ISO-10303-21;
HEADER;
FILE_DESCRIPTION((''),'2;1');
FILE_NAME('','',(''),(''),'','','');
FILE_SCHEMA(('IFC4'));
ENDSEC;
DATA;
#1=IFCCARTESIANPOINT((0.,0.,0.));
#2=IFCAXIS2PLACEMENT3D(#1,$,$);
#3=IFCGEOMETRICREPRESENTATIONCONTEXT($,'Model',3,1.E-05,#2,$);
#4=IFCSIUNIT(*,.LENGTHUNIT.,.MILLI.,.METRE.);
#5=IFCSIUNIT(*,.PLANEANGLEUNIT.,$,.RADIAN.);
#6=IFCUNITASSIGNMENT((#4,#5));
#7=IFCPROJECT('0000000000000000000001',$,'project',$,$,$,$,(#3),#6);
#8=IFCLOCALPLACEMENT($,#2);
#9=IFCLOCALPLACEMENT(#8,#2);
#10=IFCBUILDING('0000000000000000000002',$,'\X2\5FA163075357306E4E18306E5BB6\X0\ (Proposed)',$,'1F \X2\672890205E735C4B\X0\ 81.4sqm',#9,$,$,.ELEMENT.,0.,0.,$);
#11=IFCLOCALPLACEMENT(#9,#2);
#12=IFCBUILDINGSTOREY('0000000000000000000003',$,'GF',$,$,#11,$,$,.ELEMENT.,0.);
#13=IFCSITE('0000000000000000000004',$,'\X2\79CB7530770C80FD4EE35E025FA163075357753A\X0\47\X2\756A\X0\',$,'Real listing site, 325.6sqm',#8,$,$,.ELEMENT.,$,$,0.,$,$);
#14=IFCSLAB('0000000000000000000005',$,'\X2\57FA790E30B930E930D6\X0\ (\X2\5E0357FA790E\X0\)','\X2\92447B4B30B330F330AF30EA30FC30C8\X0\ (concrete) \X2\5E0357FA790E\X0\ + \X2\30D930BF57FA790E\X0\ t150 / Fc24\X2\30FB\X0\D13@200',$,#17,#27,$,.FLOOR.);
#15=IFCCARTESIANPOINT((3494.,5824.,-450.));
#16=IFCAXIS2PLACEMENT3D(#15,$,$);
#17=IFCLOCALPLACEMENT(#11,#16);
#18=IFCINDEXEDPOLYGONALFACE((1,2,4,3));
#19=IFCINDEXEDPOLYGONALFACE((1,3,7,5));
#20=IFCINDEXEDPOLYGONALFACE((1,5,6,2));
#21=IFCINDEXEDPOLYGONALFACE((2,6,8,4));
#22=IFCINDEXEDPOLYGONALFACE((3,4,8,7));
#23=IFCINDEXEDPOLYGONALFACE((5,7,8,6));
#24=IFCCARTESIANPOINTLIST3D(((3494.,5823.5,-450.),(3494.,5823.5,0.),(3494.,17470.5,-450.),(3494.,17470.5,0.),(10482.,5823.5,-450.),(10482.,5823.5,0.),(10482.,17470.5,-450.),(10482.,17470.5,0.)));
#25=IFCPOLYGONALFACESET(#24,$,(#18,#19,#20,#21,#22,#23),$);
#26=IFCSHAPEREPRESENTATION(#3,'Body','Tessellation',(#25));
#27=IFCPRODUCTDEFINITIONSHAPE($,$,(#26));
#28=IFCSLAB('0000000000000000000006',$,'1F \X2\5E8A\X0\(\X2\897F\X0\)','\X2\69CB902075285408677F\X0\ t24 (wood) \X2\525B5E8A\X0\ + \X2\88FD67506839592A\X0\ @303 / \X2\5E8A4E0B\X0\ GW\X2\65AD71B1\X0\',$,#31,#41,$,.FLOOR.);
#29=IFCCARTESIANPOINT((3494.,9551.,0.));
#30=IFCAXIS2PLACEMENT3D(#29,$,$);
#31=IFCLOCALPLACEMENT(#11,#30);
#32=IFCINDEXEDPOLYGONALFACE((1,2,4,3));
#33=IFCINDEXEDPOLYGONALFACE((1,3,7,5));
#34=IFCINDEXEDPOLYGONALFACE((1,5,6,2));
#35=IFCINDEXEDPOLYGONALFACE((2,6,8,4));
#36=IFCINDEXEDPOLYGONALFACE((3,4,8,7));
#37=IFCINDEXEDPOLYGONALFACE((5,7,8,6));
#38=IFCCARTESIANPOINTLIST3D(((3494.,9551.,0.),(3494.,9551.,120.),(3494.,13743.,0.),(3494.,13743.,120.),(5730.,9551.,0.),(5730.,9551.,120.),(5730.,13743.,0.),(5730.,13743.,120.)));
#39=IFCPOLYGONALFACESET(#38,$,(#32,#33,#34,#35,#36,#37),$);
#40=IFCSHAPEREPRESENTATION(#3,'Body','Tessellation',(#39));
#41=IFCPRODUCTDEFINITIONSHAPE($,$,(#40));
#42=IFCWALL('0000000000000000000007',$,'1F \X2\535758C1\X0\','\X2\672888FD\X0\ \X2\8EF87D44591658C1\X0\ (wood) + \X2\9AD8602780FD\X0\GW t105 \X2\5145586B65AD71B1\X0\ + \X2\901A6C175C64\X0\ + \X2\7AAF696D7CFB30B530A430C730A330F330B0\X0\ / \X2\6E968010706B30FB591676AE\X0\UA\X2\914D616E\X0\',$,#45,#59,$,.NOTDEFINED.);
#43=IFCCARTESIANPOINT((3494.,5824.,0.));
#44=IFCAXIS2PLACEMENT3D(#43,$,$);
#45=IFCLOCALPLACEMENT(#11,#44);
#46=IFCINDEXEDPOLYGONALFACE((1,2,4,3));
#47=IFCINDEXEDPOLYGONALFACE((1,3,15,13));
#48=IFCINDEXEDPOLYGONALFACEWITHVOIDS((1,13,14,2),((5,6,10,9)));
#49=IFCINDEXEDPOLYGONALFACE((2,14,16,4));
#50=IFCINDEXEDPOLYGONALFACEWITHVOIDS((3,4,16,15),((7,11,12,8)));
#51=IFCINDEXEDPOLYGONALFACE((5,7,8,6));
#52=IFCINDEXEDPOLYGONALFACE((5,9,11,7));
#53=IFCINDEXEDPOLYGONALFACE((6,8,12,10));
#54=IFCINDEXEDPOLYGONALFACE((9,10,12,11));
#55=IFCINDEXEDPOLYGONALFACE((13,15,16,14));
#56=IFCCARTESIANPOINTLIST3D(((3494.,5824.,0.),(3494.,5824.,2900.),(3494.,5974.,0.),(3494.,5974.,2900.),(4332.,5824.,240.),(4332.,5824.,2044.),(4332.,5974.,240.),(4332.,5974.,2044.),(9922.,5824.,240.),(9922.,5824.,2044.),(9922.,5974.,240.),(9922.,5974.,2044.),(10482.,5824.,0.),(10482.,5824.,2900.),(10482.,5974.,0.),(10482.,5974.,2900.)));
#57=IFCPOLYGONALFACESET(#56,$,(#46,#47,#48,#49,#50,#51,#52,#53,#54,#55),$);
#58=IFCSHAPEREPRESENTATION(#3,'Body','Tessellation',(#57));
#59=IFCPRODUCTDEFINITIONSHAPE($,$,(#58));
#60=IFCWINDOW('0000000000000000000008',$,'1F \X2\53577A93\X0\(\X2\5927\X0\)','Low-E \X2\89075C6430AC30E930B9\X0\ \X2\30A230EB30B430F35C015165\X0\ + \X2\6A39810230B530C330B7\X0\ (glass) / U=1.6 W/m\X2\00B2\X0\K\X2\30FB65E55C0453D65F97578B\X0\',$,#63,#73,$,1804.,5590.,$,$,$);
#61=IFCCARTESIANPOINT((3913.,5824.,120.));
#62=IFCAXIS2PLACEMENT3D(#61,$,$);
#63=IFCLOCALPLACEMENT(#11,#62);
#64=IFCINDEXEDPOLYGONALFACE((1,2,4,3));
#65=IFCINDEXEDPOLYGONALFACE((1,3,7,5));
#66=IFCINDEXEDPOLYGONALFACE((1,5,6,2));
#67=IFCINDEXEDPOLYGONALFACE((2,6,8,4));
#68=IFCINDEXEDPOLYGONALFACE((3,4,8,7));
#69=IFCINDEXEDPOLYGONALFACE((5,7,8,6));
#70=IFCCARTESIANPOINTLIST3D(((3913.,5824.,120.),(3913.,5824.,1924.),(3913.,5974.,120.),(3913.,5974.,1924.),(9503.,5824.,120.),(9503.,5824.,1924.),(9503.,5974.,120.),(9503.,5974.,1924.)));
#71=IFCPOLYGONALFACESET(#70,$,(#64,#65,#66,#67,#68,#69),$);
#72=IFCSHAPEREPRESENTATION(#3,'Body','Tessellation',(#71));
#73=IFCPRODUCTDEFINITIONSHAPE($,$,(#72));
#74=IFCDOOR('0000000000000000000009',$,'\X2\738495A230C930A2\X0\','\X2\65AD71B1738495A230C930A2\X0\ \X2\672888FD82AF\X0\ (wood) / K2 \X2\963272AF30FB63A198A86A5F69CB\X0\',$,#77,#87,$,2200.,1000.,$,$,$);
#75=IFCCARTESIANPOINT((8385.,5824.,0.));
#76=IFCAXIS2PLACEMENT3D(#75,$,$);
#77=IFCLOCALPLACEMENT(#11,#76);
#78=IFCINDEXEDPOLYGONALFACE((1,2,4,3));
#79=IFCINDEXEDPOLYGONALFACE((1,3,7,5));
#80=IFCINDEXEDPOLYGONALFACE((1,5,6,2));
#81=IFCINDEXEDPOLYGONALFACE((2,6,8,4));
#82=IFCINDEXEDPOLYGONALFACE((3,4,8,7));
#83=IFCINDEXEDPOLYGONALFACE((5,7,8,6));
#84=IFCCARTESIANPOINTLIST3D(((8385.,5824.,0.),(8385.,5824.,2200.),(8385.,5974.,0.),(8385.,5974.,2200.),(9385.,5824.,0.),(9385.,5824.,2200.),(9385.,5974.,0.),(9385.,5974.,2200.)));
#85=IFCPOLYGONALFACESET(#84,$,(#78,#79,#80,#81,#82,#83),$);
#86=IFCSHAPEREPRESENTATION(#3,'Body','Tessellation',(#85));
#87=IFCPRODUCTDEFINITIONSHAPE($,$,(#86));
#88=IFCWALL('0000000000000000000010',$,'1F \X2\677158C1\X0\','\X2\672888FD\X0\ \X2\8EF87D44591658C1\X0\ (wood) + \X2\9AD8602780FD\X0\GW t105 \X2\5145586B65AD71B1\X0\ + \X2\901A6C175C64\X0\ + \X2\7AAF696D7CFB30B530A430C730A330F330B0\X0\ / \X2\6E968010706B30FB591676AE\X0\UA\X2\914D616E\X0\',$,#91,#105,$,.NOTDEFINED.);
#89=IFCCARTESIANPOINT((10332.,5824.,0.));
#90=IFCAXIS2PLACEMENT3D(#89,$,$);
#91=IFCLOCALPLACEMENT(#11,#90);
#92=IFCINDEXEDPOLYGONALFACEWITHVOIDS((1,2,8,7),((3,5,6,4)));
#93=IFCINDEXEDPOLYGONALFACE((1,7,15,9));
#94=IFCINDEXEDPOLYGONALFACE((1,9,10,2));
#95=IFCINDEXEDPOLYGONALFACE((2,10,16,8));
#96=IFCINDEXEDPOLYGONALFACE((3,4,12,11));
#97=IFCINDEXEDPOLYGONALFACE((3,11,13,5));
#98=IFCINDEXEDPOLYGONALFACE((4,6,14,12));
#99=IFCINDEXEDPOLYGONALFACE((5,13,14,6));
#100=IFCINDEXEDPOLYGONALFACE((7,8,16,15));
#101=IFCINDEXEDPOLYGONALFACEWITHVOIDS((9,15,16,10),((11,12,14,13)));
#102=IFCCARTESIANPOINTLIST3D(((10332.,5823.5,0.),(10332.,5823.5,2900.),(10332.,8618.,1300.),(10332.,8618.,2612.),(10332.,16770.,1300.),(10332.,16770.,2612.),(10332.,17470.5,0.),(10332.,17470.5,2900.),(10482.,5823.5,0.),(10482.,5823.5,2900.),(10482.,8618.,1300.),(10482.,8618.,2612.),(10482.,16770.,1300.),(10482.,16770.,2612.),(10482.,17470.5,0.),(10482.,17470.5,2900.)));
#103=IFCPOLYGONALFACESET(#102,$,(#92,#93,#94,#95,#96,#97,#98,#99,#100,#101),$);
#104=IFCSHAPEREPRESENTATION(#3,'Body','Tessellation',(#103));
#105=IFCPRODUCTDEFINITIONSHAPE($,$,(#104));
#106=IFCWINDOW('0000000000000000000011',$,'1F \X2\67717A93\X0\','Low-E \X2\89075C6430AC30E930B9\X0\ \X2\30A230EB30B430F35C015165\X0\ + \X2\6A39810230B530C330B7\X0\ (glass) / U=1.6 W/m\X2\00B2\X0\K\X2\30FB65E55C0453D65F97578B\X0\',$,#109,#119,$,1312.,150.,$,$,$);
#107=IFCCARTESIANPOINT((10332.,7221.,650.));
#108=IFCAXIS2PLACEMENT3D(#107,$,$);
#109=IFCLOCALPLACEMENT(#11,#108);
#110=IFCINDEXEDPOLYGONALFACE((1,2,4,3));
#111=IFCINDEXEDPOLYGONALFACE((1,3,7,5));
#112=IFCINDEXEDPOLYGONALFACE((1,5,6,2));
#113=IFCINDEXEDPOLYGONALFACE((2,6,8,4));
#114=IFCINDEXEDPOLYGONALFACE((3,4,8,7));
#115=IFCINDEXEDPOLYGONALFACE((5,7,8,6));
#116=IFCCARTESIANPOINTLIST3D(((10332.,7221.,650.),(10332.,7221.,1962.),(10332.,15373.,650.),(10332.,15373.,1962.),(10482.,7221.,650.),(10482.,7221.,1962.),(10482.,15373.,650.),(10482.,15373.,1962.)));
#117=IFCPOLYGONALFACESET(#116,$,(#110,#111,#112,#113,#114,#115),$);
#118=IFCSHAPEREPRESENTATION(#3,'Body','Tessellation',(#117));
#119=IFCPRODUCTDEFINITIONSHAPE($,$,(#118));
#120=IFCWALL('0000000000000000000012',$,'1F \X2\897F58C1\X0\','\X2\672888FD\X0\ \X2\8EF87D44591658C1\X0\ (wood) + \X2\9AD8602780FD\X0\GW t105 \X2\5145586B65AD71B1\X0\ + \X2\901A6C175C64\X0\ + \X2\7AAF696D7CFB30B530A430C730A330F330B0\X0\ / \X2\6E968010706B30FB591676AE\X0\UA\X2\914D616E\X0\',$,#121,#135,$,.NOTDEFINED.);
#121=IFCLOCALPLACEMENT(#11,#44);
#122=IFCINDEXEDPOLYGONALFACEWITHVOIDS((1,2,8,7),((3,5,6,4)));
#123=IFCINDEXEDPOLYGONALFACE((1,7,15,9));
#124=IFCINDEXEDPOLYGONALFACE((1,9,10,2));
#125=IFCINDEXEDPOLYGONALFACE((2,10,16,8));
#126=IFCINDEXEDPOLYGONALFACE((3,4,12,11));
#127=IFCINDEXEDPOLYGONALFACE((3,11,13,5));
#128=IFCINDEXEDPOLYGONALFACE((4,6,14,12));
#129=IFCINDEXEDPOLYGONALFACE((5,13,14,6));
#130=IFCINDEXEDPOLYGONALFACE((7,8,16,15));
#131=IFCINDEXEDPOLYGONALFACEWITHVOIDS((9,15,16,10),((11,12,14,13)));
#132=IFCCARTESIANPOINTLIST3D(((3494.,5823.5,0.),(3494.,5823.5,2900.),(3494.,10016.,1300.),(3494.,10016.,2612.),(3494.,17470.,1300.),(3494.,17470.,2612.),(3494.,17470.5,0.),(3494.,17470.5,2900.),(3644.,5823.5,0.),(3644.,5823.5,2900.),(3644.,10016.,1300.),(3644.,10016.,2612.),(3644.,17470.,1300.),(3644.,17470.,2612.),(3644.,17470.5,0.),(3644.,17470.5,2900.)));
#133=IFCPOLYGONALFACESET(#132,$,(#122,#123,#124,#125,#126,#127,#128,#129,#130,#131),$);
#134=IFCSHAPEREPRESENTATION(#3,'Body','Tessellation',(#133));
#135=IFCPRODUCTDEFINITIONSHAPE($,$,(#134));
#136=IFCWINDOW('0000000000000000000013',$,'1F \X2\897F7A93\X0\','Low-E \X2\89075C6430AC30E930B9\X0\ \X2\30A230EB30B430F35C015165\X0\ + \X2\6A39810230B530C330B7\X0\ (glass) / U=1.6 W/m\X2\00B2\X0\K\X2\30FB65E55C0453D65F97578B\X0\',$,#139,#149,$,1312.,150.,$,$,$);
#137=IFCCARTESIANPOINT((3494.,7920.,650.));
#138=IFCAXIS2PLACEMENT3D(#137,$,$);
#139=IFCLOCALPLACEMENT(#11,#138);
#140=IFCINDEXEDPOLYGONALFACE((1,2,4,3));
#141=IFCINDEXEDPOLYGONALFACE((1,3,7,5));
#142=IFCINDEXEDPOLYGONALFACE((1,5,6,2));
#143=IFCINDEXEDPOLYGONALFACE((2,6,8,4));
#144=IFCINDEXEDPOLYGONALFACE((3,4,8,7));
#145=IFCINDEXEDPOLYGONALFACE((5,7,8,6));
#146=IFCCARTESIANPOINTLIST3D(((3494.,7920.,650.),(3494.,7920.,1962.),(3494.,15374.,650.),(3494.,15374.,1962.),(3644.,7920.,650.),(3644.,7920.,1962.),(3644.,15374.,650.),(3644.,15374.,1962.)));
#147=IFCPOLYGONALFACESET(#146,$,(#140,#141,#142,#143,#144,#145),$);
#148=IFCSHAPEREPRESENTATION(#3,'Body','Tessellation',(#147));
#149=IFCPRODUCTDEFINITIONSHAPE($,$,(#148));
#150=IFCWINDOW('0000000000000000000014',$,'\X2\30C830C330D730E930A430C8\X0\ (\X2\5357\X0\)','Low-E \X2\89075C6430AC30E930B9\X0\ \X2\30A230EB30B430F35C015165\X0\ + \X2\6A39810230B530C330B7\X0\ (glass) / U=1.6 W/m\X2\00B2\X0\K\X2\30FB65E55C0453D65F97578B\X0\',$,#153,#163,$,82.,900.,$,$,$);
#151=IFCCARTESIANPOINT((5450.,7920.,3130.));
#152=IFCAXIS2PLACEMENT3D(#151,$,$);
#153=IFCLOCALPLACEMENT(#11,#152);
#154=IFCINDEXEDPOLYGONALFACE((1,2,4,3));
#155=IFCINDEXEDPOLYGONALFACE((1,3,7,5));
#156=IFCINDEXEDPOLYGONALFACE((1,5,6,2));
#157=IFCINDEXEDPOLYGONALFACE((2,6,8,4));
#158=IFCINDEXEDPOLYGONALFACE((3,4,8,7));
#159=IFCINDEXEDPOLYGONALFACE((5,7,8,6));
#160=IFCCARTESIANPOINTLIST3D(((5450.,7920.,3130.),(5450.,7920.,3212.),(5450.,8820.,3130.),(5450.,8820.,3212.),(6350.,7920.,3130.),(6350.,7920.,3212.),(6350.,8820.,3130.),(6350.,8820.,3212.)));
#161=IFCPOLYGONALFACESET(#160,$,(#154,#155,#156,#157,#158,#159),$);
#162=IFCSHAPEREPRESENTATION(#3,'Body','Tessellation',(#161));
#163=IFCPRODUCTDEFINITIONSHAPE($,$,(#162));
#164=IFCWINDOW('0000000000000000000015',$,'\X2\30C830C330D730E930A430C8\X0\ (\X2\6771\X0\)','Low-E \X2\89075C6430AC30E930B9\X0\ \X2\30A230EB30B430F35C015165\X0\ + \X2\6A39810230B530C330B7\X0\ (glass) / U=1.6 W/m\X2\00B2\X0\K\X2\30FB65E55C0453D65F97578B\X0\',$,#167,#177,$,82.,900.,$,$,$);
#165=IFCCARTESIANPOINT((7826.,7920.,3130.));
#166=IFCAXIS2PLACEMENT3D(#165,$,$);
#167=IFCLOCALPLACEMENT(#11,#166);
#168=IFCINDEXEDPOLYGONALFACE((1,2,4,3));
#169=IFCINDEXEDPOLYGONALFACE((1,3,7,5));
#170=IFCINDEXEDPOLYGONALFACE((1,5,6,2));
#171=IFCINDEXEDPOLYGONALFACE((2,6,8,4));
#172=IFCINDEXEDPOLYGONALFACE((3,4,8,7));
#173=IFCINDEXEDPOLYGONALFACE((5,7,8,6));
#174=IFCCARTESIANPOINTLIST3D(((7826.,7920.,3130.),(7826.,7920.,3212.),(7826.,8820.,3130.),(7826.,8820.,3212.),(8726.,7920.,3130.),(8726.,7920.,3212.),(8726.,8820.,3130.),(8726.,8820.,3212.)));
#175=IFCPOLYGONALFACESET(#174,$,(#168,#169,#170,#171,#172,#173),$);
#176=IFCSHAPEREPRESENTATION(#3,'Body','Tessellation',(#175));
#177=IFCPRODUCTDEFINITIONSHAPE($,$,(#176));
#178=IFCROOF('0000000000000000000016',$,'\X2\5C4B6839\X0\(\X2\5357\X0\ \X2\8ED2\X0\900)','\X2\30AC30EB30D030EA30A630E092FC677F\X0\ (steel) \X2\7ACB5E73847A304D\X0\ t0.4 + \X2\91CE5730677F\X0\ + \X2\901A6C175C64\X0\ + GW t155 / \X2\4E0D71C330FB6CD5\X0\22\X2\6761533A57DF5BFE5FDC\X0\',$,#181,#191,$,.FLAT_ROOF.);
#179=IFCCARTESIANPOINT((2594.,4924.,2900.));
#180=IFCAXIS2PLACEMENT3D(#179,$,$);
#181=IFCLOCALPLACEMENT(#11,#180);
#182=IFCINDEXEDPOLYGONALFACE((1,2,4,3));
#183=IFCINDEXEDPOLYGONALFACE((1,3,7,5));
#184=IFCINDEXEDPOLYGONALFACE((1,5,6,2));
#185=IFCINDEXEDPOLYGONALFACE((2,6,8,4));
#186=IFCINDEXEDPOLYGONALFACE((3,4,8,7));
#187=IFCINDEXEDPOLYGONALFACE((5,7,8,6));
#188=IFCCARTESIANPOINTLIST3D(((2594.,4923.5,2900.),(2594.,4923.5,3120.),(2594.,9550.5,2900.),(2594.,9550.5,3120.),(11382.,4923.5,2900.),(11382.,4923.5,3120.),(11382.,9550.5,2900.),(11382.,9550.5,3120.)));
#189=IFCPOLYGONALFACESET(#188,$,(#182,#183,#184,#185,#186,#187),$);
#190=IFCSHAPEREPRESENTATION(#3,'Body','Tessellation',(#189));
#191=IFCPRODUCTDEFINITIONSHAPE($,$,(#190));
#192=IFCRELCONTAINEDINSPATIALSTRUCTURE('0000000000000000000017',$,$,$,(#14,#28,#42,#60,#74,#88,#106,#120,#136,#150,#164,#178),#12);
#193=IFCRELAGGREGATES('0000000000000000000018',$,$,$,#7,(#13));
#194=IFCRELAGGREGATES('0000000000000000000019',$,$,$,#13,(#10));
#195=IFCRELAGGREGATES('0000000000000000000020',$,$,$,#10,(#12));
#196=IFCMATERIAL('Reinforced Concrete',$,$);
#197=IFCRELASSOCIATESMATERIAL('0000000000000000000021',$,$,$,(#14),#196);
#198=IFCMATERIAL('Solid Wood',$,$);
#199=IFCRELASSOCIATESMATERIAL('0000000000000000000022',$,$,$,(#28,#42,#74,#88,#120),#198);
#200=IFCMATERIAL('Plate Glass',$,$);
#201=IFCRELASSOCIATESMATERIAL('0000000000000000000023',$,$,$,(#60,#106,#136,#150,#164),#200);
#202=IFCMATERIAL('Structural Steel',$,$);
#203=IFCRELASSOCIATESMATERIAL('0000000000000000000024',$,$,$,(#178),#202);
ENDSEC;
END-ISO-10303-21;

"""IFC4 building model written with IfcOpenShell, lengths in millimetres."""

from ifc_helpers import new_model, si_unit, frame, frame_2d, origin, place, context, project, spatial, rectangle, extrude, material, element, fill, save


model = new_model("IFC4")

# Units and contexts
model_context = context("Model", 3, precision=1e-05, world=origin())
ifc_project = project(units=[si_unit("LENGTHUNIT", "METRE", prefix="MILLI"), si_unit("PLANEANGLEUNIT", "RADIAN")], contexts=[model_context])

# Site, building, storey
site_placement = place(None, origin())
site = spatial("IfcSite", under=ifc_project, at=site_placement, Name="秋田県能代市御指南町47番", ObjectType="Real listing site, 325.6sqm", CompositionType="ELEMENT", RefElevation=0.0)
building_placement = place(site_placement, origin())
building = spatial("IfcBuilding", under=site, at=building_placement, Name="御指南の丘の家 (Proposed)", ObjectType="1F 木造平屋 81.4sqm", CompositionType="ELEMENT", ElevationOfRefHeight=0.0, ElevationOfTerrain=0.0)
storey_placement = place(building_placement, origin())
storey = spatial("IfcBuildingStorey", under=building, at=storey_placement, Name="GF", CompositionType="ELEMENT", Elevation=0.0)

# Slabs
ifc_material_1 = material(Name="Reinforced Concrete")
slab_1_placement = place(storey_placement, frame((3494.0, 5824.0, -450.0)))
element("IfcSlab", 1, at=slab_1_placement, inside=storey, material=ifc_material_1, Name="基礎スラブ (布基礎)", Description="鉄筋コンクリート (concrete) 布基礎 + ベタ基礎 t150 / Fc24・D13@200", PredefinedType="FLOOR", context=model_context, shape_type="SweptSolid", body=[
    extrude(rectangle(XDim=6988.0, YDim=11647.0, at=frame_2d((3494.0, 5823.0))), frame((3494.0, 5824.0, -450.0)), (0.0, 0.0, 1.0), 450.0),
])
ifc_material_2 = material(Name="Solid Wood")
slab_2_placement = place(storey_placement, frame((3494.0, 9551.0, 0.0)))
element("IfcSlab", 2, at=slab_2_placement, inside=storey, material=ifc_material_2, Name="1F 床(西)", Description="構造用合板 t24 (wood) 剛床 + 製材根太 @303 / 床下 GW断熱", PredefinedType="FLOOR", context=model_context, shape_type="SweptSolid", body=[
    extrude(rectangle(XDim=2236.0, YDim=4192.0, at=frame_2d((1118.0, 2096.0))), frame((3494.0, 9551.0, 0.0)), (0.0, 0.0, 1.0), 120.0),
])

# Wall, openings, window, door
wall_1_placement = place(storey_placement, frame((3494.0, 5824.0, 0.0)))
wall_1 = element("IfcWall", 3, at=wall_1_placement, inside=storey, material=ifc_material_2, Name="1F 南壁", Description="木製 軸組外壁 (wood) + 高性能GW t105 充填断熱 + 通気層 + 窯業系サイディング / 準耐火・外皮UA配慮", PredefinedType="NOTDEFINED", context=model_context, shape_type="SweptSolid", body=[
    extrude(rectangle(XDim=6988.0, YDim=150.0, at=frame_2d((3494.0, 75.0))), frame((3494.0, 5824.0, 0.0)), (0.0, 0.0, 1.0), 2900.0),
])
opening_1_placement = place(storey_placement, frame((3913.0, 5824.0, 120.0)))
opening_1 = element("IfcOpeningElement", 4, at=opening_1_placement, cuts=wall_1, PredefinedType="NOTDEFINED", context=model_context, shape_type="SweptSolid", body=[
    extrude(rectangle(XDim=5590.0, YDim=150.0, at=frame_2d((2795.0, 75.0))), frame((3913.0, 5824.0, 120.0)), (0.0, 0.0, 1.0), 1804.0),
])
opening_2_placement = place(storey_placement, frame((8385.0, 5824.0, 0.0)))
opening_2 = element("IfcOpeningElement", 5, at=opening_2_placement, cuts=wall_1, PredefinedType="NOTDEFINED", context=model_context, shape_type="SweptSolid", body=[
    extrude(rectangle(XDim=1000.0, YDim=150.0, at=frame_2d((500.0, 75.0))), frame((8385.0, 5824.0, 0.0)), (0.0, 0.0, 1.0), 2200.0),
])
ifc_material_3 = material(Name="Plate Glass")
window_1_placement = place(storey_placement, frame((3913.0, 5824.0, 120.0)))
window_1 = element("IfcWindow", 6, at=window_1_placement, inside=storey, material=ifc_material_3, Name="1F 南窓(大)", Description="Low-E 複層ガラス アルゴン封入 + 樹脂サッシ (glass) / U=1.6 W/m²K・日射取得型", OverallHeight=1804.0, OverallWidth=5590.0, context=model_context, shape_type="SweptSolid", body=[
    extrude(rectangle(XDim=5590.0, YDim=150.0, at=frame_2d((2795.0, 75.0))), frame((3913.0, 5824.0, 120.0)), (0.0, 0.0, 1.0), 1804.0),
])
fill(opening_1, window_1)
door_placement = place(storey_placement, frame((8385.0, 5824.0, 0.0)))
door = element("IfcDoor", 7, at=door_placement, inside=storey, material=ifc_material_2, Name="玄関ドア", Description="断熱玄関ドア 木製芯 (wood) / K2 防犯・採風機構", OverallHeight=2200.0, OverallWidth=1000.0, context=model_context, shape_type="SweptSolid", body=[
    extrude(rectangle(XDim=1000.0, YDim=150.0, at=frame_2d((500.0, 75.0))), frame((8385.0, 5824.0, 0.0)), (0.0, 0.0, 1.0), 2200.0),
])
fill(opening_2, door)

# Walls, openings, windows
wall_2_placement = place(storey_placement, frame((10332.0, 5824.0, 0.0)))
wall_2 = element("IfcWall", 8, at=wall_2_placement, inside=storey, material=ifc_material_2, Name="1F 東壁", Description="木製 軸組外壁 (wood) + 高性能GW t105 充填断熱 + 通気層 + 窯業系サイディング / 準耐火・外皮UA配慮", PredefinedType="NOTDEFINED", context=model_context, shape_type="SweptSolid", body=[
    extrude(rectangle(XDim=150.0, YDim=11647.0, at=frame_2d((75.0, 5823.0))), frame((10332.0, 5824.0, 0.0)), (0.0, 0.0, 1.0), 2900.0),
])
opening_3_placement = place(storey_placement, frame((10332.0, 7221.0, 650.0)))
opening_3 = element("IfcOpeningElement", 9, at=opening_3_placement, cuts=wall_2, PredefinedType="NOTDEFINED", context=model_context, shape_type="SweptSolid", body=[
    extrude(rectangle(XDim=150.0, YDim=8152.0, at=frame_2d((75.0, 4076.0))), frame((10332.0, 7221.0, 650.0)), (0.0, 0.0, 1.0), 1312.0),
])
window_2_placement = place(storey_placement, frame((10332.0, 7221.0, 650.0)))
window_2 = element("IfcWindow", 10, at=window_2_placement, inside=storey, material=ifc_material_3, Name="1F 東窓", Description="Low-E 複層ガラス アルゴン封入 + 樹脂サッシ (glass) / U=1.6 W/m²K・日射取得型", OverallHeight=1312.0, OverallWidth=150.0, context=model_context, shape_type="SweptSolid", body=[
    extrude(rectangle(XDim=150.0, YDim=8152.0, at=frame_2d((75.0, 4076.0))), frame((10332.0, 7221.0, 650.0)), (0.0, 0.0, 1.0), 1312.0),
])
fill(opening_3, window_2)
wall_3_placement = place(storey_placement, frame((3494.0, 5824.0, 0.0)))
wall_3 = element("IfcWall", 11, at=wall_3_placement, inside=storey, material=ifc_material_2, Name="1F 西壁", Description="木製 軸組外壁 (wood) + 高性能GW t105 充填断熱 + 通気層 + 窯業系サイディング / 準耐火・外皮UA配慮", PredefinedType="NOTDEFINED", context=model_context, shape_type="SweptSolid", body=[
    extrude(rectangle(XDim=150.0, YDim=11647.0, at=frame_2d((75.0, 5823.0))), frame((3494.0, 5824.0, 0.0)), (0.0, 0.0, 1.0), 2900.0),
])
opening_4_placement = place(storey_placement, frame((3494.0, 7920.0, 650.0)))
opening_4 = element("IfcOpeningElement", 12, at=opening_4_placement, cuts=wall_3, PredefinedType="NOTDEFINED", context=model_context, shape_type="SweptSolid", body=[
    extrude(rectangle(XDim=150.0, YDim=7454.0, at=frame_2d((75.0, 3727.0))), frame((3494.0, 7920.0, 650.0)), (0.0, 0.0, 1.0), 1312.0),
])
window_3_placement = place(storey_placement, frame((3494.0, 7920.0, 650.0)))
window_3 = element("IfcWindow", 13, at=window_3_placement, inside=storey, material=ifc_material_3, Name="1F 西窓", Description="Low-E 複層ガラス アルゴン封入 + 樹脂サッシ (glass) / U=1.6 W/m²K・日射取得型", OverallHeight=1312.0, OverallWidth=150.0, context=model_context, shape_type="SweptSolid", body=[
    extrude(rectangle(XDim=150.0, YDim=7454.0, at=frame_2d((75.0, 3727.0))), frame((3494.0, 7920.0, 650.0)), (0.0, 0.0, 1.0), 1312.0),
])
fill(opening_4, window_3)

# Windows
window_4_placement = place(storey_placement, frame((5450.0, 7920.0, 3130.0)))
element("IfcWindow", 14, at=window_4_placement, inside=storey, material=ifc_material_3, Name="トップライト (南)", Description="Low-E 複層ガラス アルゴン封入 + 樹脂サッシ (glass) / U=1.6 W/m²K・日射取得型", OverallHeight=82.0, OverallWidth=900.0, context=model_context, shape_type="SweptSolid", body=[
    extrude(rectangle(XDim=900.0, YDim=900.0, at=frame_2d((450.0, 450.0))), frame((5450.0, 7920.0, 3130.0)), (0.0, 0.0, 1.0), 82.0),
])
window_5_placement = place(storey_placement, frame((7826.0, 7920.0, 3130.0)))
element("IfcWindow", 15, at=window_5_placement, inside=storey, material=ifc_material_3, Name="トップライト (東)", Description="Low-E 複層ガラス アルゴン封入 + 樹脂サッシ (glass) / U=1.6 W/m²K・日射取得型", OverallHeight=82.0, OverallWidth=900.0, context=model_context, shape_type="SweptSolid", body=[
    extrude(rectangle(XDim=900.0, YDim=900.0, at=frame_2d((450.0, 450.0))), frame((7826.0, 7920.0, 3130.0)), (0.0, 0.0, 1.0), 82.0),
])

# Roof
ifc_material_4 = material(Name="Structural Steel")
roof_placement = place(storey_placement, frame((2594.0, 4924.0, 2900.0)))
element("IfcRoof", 16, at=roof_placement, inside=storey, material=ifc_material_4, Name="屋根(南 軒900)", Description="ガルバリウム鋼板 (steel) 立平葺き t0.4 + 野地板 + 通気層 + GW t155 / 不燃・法22条区域対応", PredefinedType="FLAT_ROOF", context=model_context, shape_type="SweptSolid", body=[
    extrude(rectangle(XDim=8788.0, YDim=4627.0, at=frame_2d((4394.0, 2313.0))), frame((2594.0, 4924.0, 2900.0)), (0.0, 0.0, 1.0), 220.0),
])

save(model, "model.ifc")
